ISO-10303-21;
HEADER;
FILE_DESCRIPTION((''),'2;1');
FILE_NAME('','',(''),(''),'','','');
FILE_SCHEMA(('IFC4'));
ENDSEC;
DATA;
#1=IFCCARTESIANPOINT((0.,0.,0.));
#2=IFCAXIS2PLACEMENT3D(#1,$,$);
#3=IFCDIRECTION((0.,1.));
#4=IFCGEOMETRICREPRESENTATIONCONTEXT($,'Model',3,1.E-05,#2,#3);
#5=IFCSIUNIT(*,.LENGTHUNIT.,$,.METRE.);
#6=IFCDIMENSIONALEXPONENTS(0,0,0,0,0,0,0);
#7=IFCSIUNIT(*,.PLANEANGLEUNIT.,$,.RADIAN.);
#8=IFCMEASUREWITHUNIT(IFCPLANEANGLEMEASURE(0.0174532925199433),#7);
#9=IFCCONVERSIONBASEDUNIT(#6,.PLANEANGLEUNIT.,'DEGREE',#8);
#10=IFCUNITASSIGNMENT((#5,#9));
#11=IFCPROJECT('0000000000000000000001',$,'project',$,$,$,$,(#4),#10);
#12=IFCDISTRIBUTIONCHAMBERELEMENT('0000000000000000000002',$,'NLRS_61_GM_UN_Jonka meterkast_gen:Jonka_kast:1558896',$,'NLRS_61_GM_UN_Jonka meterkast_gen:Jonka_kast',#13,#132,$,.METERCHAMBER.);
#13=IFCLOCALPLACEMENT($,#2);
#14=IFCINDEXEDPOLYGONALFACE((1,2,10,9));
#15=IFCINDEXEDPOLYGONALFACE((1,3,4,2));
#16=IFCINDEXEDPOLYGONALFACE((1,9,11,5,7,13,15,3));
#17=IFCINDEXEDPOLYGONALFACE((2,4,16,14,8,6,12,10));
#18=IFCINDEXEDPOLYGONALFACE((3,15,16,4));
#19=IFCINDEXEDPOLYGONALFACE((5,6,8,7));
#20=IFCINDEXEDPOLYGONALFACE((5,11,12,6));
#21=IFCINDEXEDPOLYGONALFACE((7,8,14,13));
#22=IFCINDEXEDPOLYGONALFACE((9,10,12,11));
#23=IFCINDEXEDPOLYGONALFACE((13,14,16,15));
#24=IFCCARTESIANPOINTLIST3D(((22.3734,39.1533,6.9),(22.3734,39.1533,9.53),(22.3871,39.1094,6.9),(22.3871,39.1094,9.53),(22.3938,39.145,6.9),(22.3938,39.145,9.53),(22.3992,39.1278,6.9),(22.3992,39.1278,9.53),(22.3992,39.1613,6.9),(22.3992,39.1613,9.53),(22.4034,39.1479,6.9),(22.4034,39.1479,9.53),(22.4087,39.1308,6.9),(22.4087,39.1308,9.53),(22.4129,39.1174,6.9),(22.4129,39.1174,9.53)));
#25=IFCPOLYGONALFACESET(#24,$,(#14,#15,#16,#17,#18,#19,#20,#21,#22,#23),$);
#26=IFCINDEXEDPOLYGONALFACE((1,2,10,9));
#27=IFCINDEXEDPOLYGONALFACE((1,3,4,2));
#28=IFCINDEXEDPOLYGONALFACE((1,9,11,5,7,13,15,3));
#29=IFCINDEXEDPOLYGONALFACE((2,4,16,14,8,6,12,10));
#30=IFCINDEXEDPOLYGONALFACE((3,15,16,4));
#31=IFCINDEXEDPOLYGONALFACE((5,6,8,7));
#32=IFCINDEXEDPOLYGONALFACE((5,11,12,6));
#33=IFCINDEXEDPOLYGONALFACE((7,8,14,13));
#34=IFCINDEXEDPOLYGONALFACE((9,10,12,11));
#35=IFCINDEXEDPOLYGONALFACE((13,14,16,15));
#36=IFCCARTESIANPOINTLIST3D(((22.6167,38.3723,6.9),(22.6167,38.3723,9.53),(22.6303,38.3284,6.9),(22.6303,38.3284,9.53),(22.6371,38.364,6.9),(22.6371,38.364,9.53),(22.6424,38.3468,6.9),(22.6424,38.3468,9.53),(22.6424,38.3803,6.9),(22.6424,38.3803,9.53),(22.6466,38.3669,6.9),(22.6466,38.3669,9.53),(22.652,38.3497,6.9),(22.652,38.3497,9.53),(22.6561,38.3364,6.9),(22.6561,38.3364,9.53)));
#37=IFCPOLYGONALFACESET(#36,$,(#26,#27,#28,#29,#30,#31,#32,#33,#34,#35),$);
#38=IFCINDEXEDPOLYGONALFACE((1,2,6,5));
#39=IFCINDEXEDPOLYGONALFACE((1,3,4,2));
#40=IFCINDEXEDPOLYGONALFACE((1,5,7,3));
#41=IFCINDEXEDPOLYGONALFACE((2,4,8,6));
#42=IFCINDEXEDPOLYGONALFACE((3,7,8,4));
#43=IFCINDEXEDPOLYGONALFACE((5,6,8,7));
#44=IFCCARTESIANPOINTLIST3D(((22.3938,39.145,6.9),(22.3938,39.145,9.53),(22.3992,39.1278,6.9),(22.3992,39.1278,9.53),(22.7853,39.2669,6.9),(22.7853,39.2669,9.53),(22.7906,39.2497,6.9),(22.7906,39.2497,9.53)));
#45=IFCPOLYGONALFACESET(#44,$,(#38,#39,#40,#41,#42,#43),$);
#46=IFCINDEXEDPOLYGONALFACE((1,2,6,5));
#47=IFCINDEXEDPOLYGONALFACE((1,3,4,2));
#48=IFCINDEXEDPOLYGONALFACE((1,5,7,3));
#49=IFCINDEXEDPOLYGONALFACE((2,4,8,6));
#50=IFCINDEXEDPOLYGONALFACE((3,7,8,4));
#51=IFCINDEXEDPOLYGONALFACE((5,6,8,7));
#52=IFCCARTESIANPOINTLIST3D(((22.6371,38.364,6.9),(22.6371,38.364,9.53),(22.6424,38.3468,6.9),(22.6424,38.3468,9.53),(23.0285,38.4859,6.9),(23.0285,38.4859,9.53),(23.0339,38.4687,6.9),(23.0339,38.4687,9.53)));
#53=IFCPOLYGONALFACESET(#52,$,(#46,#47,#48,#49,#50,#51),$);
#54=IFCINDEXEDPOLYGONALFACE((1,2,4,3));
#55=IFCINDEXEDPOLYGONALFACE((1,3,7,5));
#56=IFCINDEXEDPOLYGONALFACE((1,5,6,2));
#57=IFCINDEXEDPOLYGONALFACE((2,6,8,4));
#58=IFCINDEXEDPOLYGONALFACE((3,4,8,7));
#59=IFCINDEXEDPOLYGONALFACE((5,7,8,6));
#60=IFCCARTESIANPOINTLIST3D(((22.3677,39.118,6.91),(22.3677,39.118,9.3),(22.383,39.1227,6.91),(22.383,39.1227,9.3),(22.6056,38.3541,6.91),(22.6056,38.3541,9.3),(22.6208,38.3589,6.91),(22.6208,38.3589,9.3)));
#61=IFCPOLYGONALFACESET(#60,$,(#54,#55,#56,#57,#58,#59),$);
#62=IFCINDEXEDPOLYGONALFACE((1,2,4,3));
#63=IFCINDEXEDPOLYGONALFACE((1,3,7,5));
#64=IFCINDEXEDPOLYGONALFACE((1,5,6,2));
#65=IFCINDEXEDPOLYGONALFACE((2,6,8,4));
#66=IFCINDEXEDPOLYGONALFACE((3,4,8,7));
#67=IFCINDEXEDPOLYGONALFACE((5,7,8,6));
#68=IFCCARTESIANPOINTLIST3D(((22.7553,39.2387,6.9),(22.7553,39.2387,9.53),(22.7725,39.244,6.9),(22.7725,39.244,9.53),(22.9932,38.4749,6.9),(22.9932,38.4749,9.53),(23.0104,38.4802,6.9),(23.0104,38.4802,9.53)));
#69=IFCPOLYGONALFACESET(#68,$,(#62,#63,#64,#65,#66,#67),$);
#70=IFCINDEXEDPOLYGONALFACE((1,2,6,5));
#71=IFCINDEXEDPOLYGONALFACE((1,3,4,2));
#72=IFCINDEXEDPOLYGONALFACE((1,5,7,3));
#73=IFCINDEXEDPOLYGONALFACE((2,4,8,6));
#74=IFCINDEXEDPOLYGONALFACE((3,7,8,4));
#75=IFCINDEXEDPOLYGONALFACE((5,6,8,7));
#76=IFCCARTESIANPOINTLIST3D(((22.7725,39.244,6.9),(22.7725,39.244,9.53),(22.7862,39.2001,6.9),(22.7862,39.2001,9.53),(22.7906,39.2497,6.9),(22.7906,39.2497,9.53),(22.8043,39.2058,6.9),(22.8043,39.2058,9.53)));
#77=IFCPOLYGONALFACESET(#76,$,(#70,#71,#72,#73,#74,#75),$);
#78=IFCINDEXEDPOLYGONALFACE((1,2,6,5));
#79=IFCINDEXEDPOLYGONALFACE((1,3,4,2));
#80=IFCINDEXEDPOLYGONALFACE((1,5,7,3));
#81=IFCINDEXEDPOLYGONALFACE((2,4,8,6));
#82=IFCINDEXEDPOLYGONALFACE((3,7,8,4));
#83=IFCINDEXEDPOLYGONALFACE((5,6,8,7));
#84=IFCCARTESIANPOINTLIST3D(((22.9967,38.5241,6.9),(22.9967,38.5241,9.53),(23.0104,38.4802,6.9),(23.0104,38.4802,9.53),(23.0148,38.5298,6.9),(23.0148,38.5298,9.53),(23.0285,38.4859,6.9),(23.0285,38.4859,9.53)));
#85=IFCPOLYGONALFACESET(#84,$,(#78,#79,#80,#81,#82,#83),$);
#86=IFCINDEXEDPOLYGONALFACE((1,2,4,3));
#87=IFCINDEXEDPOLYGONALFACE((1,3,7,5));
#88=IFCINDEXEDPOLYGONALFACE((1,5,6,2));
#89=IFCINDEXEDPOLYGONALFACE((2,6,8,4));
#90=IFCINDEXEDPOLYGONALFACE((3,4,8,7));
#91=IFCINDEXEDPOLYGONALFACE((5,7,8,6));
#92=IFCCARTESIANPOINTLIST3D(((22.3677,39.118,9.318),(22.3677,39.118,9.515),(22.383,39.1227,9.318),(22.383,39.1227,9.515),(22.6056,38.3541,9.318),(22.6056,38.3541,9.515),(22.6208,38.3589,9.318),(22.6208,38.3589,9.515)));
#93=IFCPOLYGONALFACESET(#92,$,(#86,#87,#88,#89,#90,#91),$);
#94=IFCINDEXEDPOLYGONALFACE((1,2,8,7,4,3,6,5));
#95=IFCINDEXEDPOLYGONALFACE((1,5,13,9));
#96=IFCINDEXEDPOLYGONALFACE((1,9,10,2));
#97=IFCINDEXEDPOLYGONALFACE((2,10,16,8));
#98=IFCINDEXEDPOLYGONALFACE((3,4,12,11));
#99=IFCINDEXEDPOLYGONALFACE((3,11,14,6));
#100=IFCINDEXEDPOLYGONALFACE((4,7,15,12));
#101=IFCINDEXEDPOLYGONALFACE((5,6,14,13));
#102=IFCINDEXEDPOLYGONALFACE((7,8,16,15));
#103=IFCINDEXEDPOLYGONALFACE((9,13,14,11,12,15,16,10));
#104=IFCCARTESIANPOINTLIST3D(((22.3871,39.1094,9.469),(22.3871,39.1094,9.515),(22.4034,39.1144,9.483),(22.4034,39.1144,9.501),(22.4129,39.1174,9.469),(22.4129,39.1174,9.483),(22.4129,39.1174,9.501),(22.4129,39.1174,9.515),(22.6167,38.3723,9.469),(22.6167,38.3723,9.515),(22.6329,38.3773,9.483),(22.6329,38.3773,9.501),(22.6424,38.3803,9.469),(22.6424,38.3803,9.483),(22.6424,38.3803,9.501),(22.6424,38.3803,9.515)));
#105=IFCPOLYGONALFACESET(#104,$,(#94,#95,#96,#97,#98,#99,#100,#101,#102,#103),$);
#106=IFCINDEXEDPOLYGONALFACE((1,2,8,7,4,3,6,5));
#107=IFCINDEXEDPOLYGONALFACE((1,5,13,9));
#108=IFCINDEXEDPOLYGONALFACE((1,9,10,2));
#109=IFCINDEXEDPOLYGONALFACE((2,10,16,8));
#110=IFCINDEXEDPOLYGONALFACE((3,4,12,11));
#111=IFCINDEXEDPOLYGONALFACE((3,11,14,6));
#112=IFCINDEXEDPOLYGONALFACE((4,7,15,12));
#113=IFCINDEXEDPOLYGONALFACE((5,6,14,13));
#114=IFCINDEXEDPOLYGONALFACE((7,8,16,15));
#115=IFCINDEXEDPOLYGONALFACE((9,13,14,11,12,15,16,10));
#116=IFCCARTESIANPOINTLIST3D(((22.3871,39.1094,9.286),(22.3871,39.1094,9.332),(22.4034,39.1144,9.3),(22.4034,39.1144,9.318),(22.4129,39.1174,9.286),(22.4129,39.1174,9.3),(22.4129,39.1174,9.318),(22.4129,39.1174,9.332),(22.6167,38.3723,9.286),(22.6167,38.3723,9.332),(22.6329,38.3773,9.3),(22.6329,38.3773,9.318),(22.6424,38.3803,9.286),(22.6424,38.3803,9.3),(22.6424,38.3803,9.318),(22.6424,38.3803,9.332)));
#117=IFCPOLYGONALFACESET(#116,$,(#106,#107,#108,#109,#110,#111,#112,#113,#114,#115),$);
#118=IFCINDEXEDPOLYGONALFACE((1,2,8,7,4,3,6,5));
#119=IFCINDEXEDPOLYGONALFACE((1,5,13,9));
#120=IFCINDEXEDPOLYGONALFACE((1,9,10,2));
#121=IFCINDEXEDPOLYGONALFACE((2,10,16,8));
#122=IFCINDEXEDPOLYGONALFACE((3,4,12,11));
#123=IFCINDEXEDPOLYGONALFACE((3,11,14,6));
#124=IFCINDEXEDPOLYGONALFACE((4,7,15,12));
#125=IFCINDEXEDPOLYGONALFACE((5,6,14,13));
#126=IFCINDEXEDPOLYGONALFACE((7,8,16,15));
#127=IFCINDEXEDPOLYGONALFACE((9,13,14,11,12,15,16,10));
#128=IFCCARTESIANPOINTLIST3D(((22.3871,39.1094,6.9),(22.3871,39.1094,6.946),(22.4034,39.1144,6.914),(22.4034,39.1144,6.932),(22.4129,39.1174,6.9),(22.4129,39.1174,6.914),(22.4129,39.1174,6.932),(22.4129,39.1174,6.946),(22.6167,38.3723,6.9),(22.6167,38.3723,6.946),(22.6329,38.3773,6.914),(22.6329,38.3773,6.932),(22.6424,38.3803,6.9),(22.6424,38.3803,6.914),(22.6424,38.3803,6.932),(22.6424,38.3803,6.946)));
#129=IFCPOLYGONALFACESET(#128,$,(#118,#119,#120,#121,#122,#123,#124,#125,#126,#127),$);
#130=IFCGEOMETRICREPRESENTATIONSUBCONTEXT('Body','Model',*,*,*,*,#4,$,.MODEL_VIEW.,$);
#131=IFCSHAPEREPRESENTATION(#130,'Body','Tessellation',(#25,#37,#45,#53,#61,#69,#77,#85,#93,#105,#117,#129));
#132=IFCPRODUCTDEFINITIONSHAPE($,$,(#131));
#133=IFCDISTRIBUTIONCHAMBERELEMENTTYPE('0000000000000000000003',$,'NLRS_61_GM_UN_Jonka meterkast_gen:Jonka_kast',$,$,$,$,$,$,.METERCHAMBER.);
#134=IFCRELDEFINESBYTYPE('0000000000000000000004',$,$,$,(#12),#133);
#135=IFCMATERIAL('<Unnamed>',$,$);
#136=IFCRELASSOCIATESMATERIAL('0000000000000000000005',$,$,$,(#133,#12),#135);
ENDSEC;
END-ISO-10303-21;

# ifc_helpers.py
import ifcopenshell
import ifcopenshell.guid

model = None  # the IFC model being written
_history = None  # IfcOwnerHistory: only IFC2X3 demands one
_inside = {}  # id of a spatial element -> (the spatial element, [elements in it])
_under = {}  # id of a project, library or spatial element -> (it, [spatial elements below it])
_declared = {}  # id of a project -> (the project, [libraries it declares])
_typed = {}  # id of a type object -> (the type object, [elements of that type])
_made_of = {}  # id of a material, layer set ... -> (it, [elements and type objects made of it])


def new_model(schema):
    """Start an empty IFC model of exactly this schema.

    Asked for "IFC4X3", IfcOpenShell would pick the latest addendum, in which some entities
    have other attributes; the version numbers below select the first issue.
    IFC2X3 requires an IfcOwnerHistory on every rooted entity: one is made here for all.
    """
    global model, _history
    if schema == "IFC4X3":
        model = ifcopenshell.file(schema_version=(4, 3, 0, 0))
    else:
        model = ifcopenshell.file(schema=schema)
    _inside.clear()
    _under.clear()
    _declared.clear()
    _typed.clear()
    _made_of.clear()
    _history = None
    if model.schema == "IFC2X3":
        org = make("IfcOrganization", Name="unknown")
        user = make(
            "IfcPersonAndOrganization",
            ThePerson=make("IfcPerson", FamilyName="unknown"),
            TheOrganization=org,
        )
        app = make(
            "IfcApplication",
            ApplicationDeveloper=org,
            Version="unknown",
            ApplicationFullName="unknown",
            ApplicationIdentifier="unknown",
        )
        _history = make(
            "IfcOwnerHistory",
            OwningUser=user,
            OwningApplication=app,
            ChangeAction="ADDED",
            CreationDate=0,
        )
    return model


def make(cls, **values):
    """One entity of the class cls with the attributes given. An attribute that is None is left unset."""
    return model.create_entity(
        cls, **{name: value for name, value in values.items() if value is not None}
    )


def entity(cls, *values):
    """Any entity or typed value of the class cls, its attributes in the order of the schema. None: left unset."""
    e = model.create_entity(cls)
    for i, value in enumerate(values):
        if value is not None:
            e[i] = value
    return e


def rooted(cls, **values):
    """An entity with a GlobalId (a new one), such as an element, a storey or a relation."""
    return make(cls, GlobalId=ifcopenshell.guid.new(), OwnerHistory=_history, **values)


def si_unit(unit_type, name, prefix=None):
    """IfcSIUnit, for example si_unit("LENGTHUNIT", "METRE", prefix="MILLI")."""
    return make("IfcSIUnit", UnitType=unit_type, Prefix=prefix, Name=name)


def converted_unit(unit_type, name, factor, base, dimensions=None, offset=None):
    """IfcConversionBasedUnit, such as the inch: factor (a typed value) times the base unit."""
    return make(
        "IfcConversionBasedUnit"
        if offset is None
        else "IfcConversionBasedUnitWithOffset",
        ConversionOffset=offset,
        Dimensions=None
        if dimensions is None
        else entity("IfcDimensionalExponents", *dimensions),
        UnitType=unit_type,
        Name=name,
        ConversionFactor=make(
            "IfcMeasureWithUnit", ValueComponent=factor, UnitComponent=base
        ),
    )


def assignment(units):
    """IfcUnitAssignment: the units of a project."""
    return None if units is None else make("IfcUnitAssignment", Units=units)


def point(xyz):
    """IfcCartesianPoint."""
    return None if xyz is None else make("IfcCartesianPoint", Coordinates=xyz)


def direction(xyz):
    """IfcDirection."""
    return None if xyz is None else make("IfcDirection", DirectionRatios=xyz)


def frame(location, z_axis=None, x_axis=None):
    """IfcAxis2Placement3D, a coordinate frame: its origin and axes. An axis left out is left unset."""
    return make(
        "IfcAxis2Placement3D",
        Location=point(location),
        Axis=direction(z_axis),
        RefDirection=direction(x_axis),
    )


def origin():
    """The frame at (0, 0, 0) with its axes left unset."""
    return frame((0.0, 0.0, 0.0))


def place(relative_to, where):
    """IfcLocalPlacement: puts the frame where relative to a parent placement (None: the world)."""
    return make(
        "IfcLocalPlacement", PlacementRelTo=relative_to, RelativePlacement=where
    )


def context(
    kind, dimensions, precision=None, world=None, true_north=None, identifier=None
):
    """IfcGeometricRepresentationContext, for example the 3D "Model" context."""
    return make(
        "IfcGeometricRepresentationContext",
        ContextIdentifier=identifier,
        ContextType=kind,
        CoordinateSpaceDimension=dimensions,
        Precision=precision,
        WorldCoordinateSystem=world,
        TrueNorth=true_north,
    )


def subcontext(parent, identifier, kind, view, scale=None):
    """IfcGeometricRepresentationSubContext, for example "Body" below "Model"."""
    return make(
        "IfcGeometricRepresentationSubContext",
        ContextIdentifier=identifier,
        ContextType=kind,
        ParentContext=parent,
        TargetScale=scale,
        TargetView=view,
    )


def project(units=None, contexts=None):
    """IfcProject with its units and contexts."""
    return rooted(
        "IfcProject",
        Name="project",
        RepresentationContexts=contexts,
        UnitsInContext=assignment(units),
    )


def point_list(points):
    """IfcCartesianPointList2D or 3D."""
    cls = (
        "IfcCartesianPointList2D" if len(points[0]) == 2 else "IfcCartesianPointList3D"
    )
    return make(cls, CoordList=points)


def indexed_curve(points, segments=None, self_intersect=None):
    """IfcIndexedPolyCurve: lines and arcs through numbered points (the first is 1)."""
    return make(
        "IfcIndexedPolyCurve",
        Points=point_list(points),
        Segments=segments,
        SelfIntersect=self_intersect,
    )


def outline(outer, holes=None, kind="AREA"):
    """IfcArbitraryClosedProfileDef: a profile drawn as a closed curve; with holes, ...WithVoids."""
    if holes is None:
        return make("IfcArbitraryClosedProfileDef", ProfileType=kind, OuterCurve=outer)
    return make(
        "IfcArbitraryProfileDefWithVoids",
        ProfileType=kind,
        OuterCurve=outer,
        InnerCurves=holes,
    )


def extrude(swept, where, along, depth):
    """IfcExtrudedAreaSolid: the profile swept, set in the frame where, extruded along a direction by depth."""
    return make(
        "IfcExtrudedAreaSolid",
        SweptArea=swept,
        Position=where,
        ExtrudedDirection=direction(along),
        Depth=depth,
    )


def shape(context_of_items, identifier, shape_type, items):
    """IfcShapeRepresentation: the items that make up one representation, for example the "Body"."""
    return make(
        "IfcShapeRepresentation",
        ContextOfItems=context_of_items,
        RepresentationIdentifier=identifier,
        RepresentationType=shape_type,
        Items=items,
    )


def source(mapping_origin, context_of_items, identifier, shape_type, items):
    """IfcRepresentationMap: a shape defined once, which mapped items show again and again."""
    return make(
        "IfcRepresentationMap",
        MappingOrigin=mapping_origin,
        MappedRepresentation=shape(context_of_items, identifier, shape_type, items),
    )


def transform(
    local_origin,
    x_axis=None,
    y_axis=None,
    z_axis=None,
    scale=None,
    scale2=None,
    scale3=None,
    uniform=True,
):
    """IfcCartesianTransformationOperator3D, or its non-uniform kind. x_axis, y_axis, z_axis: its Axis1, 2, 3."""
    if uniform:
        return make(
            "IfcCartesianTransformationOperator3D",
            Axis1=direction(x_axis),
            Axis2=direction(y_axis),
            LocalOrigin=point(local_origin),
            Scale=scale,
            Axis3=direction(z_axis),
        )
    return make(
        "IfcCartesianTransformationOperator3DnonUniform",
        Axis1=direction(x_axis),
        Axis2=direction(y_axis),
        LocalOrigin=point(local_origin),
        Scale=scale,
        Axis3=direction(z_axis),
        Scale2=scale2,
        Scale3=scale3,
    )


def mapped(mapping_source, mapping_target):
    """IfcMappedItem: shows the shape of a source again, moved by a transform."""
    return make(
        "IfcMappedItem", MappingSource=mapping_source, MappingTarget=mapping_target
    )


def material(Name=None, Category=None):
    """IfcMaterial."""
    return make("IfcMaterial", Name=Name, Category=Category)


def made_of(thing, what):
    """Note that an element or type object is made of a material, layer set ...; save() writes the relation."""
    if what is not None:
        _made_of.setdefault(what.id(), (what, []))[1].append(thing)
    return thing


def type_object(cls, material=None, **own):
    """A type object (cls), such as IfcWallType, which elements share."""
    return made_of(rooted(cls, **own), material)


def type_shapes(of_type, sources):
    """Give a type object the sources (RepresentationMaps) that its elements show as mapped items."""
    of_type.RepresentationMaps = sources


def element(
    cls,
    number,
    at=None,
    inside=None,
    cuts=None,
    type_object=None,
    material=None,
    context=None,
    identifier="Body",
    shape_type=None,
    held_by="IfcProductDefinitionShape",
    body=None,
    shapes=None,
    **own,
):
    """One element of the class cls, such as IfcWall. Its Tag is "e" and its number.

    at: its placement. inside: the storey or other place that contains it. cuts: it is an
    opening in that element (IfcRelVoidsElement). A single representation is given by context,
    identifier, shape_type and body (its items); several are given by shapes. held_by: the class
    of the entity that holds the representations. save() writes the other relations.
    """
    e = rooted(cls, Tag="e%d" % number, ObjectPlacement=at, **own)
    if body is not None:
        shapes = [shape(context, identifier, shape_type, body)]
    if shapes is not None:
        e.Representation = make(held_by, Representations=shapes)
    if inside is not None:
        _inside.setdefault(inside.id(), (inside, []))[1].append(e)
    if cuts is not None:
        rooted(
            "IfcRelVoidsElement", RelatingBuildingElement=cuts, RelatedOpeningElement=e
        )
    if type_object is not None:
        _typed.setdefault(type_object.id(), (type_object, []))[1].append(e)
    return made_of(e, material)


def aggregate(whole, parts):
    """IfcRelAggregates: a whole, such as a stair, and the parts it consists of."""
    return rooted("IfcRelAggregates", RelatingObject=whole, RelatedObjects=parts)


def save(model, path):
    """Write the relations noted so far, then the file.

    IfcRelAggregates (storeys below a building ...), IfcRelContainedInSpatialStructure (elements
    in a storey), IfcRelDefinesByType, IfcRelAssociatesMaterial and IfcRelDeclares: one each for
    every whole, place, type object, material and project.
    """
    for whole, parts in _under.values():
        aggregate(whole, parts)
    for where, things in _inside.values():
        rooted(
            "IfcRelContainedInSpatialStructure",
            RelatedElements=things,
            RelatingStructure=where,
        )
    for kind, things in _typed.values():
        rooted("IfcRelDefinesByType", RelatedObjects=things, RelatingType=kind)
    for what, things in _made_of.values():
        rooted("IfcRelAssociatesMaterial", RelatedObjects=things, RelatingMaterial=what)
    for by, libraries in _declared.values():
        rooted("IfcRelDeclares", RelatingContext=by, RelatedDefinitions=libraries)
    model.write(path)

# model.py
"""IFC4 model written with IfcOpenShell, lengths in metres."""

from ifc_helpers import new_model, entity, si_unit, converted_unit, direction, frame, origin, place, context, subcontext, project, indexed_curve, outline, extrude, source, transform, mapped, material, type_object, type_shapes, element, save


model = new_model("IFC4")

# Units and contexts
model_context = context("Model", 3, precision=1e-05, world=origin(), true_north=direction((0.0, 1.0)))
body_context = subcontext(model_context, "Body", "Model", "MODEL_VIEW")
ifc_project = project(units=[si_unit("LENGTHUNIT", "METRE"), converted_unit("PLANEANGLEUNIT", "DEGREE", entity("IfcPlaneAngleMeasure", 0.0174532925199433), si_unit("PLANEANGLEUNIT", "RADIAN"), dimensions=[0, 0, 0, 0, 0, 0, 0])], contexts=[model_context])

# Distribution chamber element
ifc_material = material(Name="<Unnamed>")
distribution_chamber_element_type = type_object("IfcDistributionChamberElementType", Name="NLRS_61_GM_UN_Jonka meterkast_gen:Jonka_kast", PredefinedType="METERCHAMBER", material=ifc_material)
shared_shape_1 = source(origin(), body_context, "Body", "SweptSolid", [
    extrude(outline(indexed_curve([(-0.0093, -0.023), (0.0178, -0.023), (0.0178, 0.023), (-0.0093, 0.023), (-0.0093, 0.009), (0.0007, 0.009), (0.0007, -0.009), (-0.0093, -0.009), (-0.0093, -0.023)], self_intersect=False)), frame((-0.409, -0.4092, 0.0), z_axis=(0.0, 0.0, 1.0), x_axis=(0.0, -1.0, 0.0)), (0.0, 0.0, 1.0), 2.63),
    extrude(outline(indexed_curve([(-0.0093, -0.023), (0.0178, -0.023), (0.0178, 0.023), (-0.0093, 0.023), (-0.0093, 0.009), (0.0007, 0.009), (0.0007, -0.009), (-0.0093, -0.009), (-0.0093, -0.023)], self_intersect=False)), frame((0.409, -0.4092, 0.0), z_axis=(0.0, 0.0, 1.0), x_axis=(0.0, -1.0, 0.0)), (0.0, 0.0, 1.0), 2.63),
    extrude(outline(indexed_curve([(-0.205, -0.009), (0.205, -0.009), (0.205, 0.009), (-0.205, 0.009), (-0.205, -0.009)], self_intersect=False)), frame((-0.409, -0.205, 0.0), z_axis=(0.0, 0.0, 1.0), x_axis=(0.0, -1.0, 0.0)), (0.0, 0.0, 1.0), 2.63),
    extrude(outline(indexed_curve([(-0.205, -0.009), (0.205, -0.009), (0.205, 0.009), (-0.205, 0.009), (-0.205, -0.009)], self_intersect=False)), frame((0.409, -0.205, 0.0), z_axis=(0.0, 0.0, 1.0), x_axis=(0.0, -1.0, 0.0)), (0.0, 0.0, 1.0), 2.63),
    extrude(outline(indexed_curve([(-0.4, -0.008), (0.4, -0.008), (0.4, 0.008), (-0.4, 0.008), (-0.4, -0.008)], self_intersect=False)), frame((0.0, -0.435, 0.01), z_axis=(0.0, 0.0, 1.0), x_axis=(-1.0, 0.0, 0.0)), (0.0, 0.0, 1.0), 2.39),
    extrude(outline(indexed_curve([(-0.4, -0.009), (0.4, -0.009), (0.4, 0.009), (-0.4, 0.009), (-0.4, -0.009)], self_intersect=False)), frame((0.0, -0.028, 0.0), z_axis=(0.0, 0.0, 1.0), x_axis=(-1.0, 0.0, 0.0)), (0.0, 0.0, 1.0), 2.63),
    extrude(outline(indexed_curve([(-0.023, -0.0095), (0.023, -0.0095), (0.023, 0.0095), (-0.023, 0.0095), (-0.023, -0.0095)], self_intersect=False)), frame((-0.377, -0.0095, 0.0), z_axis=(0.0, 0.0, 1.0), x_axis=(-1.0, 0.0, 0.0)), (0.0, 0.0, 1.0), 2.63),
    extrude(outline(indexed_curve([(-0.023, -0.0095), (0.023, -0.0095), (0.023, 0.0095), (-0.023, 0.0095), (-0.023, -0.0095)], self_intersect=False)), frame((0.377, -0.0095, 0.0), z_axis=(0.0, 0.0, 1.0), x_axis=(-1.0, 0.0, 0.0)), (0.0, 0.0, 1.0), 2.63),
    extrude(outline(indexed_curve([(-0.4, -0.008), (0.4, -0.008), (0.4, 0.008), (-0.4, 0.008), (-0.4, -0.008)], self_intersect=False)), frame((0.0, -0.435, 2.418), z_axis=(0.0, 0.0, 1.0), x_axis=(-1.0, 0.0, 0.0)), (0.0, 0.0, 1.0), 0.197),
    extrude(outline(indexed_curve([(-0.023, -0.0178), (0.023, -0.0178), (0.023, 0.0093), (0.009, 0.0093), (0.009, -0.0007), (-0.009, -0.0007), (-0.009, 0.0093), (-0.023, 0.0093), (-0.023, -0.0178)], self_intersect=False)), frame((-0.386, -0.4092, 2.592), z_axis=(1.0, 0.0, 0.0), x_axis=(0.0, 0.0, -1.0)), (0.0, 0.0, 1.0), 0.772),
    extrude(outline(indexed_curve([(-0.023, -0.0178), (0.023, -0.0178), (0.023, 0.0093), (0.009, 0.0093), (0.009, -0.0007), (-0.009, -0.0007), (-0.009, 0.0093), (-0.023, 0.0093), (-0.023, -0.0178)], self_intersect=False)), frame((-0.386, -0.4092, 2.409), z_axis=(1.0, 0.0, 0.0), x_axis=(0.0, 0.0, -1.0)), (0.0, 0.0, 1.0), 0.772),
    extrude(outline(indexed_curve([(-0.023, -0.0178), (0.023, -0.0178), (0.023, 0.0093), (0.009, 0.0093), (0.009, -0.0007), (-0.009, -0.0007), (-0.009, 0.0093), (-0.023, 0.0093), (-0.023, -0.0178)], self_intersect=False)), frame((-0.386, -0.4092, 0.023), z_axis=(1.0, 0.0, 0.0), x_axis=(0.0, 0.0, -1.0)), (0.0, 0.0, 1.0), 0.772),
])
type_shapes(distribution_chamber_element_type, [shared_shape_1])
placement_1 = place(None, frame((13.1348, 11.9886, 0.0), z_axis=(0.0, 0.0, 1.0), x_axis=(0.954771, 0.297342, 0.0)))
placement_2 = place(placement_1, origin())
placement_3 = place(placement_2, frame((0.0, 0.0, 6.9)))
placement_4 = place(placement_3, origin())
distribution_chamber_element_1_placement = place(placement_4, frame((17.325, 22.757, 0.0), z_axis=(0.0, 0.0, 1.0), x_axis=(0.0, -1.0, 0.0)))
element("IfcDistributionChamberElement", 1, at=distribution_chamber_element_1_placement, type_object=distribution_chamber_element_type, material=ifc_material, Name="NLRS_61_GM_UN_Jonka meterkast_gen:Jonka_kast:1558896", ObjectType="NLRS_61_GM_UN_Jonka meterkast_gen:Jonka_kast", PredefinedType="METERCHAMBER", context=body_context, shape_type="MappedRepresentation", body=[
    mapped(shared_shape_1, transform((0.0, 0.0, 0.0), scale=1.0)),
])

save(model, "model.ifc")
